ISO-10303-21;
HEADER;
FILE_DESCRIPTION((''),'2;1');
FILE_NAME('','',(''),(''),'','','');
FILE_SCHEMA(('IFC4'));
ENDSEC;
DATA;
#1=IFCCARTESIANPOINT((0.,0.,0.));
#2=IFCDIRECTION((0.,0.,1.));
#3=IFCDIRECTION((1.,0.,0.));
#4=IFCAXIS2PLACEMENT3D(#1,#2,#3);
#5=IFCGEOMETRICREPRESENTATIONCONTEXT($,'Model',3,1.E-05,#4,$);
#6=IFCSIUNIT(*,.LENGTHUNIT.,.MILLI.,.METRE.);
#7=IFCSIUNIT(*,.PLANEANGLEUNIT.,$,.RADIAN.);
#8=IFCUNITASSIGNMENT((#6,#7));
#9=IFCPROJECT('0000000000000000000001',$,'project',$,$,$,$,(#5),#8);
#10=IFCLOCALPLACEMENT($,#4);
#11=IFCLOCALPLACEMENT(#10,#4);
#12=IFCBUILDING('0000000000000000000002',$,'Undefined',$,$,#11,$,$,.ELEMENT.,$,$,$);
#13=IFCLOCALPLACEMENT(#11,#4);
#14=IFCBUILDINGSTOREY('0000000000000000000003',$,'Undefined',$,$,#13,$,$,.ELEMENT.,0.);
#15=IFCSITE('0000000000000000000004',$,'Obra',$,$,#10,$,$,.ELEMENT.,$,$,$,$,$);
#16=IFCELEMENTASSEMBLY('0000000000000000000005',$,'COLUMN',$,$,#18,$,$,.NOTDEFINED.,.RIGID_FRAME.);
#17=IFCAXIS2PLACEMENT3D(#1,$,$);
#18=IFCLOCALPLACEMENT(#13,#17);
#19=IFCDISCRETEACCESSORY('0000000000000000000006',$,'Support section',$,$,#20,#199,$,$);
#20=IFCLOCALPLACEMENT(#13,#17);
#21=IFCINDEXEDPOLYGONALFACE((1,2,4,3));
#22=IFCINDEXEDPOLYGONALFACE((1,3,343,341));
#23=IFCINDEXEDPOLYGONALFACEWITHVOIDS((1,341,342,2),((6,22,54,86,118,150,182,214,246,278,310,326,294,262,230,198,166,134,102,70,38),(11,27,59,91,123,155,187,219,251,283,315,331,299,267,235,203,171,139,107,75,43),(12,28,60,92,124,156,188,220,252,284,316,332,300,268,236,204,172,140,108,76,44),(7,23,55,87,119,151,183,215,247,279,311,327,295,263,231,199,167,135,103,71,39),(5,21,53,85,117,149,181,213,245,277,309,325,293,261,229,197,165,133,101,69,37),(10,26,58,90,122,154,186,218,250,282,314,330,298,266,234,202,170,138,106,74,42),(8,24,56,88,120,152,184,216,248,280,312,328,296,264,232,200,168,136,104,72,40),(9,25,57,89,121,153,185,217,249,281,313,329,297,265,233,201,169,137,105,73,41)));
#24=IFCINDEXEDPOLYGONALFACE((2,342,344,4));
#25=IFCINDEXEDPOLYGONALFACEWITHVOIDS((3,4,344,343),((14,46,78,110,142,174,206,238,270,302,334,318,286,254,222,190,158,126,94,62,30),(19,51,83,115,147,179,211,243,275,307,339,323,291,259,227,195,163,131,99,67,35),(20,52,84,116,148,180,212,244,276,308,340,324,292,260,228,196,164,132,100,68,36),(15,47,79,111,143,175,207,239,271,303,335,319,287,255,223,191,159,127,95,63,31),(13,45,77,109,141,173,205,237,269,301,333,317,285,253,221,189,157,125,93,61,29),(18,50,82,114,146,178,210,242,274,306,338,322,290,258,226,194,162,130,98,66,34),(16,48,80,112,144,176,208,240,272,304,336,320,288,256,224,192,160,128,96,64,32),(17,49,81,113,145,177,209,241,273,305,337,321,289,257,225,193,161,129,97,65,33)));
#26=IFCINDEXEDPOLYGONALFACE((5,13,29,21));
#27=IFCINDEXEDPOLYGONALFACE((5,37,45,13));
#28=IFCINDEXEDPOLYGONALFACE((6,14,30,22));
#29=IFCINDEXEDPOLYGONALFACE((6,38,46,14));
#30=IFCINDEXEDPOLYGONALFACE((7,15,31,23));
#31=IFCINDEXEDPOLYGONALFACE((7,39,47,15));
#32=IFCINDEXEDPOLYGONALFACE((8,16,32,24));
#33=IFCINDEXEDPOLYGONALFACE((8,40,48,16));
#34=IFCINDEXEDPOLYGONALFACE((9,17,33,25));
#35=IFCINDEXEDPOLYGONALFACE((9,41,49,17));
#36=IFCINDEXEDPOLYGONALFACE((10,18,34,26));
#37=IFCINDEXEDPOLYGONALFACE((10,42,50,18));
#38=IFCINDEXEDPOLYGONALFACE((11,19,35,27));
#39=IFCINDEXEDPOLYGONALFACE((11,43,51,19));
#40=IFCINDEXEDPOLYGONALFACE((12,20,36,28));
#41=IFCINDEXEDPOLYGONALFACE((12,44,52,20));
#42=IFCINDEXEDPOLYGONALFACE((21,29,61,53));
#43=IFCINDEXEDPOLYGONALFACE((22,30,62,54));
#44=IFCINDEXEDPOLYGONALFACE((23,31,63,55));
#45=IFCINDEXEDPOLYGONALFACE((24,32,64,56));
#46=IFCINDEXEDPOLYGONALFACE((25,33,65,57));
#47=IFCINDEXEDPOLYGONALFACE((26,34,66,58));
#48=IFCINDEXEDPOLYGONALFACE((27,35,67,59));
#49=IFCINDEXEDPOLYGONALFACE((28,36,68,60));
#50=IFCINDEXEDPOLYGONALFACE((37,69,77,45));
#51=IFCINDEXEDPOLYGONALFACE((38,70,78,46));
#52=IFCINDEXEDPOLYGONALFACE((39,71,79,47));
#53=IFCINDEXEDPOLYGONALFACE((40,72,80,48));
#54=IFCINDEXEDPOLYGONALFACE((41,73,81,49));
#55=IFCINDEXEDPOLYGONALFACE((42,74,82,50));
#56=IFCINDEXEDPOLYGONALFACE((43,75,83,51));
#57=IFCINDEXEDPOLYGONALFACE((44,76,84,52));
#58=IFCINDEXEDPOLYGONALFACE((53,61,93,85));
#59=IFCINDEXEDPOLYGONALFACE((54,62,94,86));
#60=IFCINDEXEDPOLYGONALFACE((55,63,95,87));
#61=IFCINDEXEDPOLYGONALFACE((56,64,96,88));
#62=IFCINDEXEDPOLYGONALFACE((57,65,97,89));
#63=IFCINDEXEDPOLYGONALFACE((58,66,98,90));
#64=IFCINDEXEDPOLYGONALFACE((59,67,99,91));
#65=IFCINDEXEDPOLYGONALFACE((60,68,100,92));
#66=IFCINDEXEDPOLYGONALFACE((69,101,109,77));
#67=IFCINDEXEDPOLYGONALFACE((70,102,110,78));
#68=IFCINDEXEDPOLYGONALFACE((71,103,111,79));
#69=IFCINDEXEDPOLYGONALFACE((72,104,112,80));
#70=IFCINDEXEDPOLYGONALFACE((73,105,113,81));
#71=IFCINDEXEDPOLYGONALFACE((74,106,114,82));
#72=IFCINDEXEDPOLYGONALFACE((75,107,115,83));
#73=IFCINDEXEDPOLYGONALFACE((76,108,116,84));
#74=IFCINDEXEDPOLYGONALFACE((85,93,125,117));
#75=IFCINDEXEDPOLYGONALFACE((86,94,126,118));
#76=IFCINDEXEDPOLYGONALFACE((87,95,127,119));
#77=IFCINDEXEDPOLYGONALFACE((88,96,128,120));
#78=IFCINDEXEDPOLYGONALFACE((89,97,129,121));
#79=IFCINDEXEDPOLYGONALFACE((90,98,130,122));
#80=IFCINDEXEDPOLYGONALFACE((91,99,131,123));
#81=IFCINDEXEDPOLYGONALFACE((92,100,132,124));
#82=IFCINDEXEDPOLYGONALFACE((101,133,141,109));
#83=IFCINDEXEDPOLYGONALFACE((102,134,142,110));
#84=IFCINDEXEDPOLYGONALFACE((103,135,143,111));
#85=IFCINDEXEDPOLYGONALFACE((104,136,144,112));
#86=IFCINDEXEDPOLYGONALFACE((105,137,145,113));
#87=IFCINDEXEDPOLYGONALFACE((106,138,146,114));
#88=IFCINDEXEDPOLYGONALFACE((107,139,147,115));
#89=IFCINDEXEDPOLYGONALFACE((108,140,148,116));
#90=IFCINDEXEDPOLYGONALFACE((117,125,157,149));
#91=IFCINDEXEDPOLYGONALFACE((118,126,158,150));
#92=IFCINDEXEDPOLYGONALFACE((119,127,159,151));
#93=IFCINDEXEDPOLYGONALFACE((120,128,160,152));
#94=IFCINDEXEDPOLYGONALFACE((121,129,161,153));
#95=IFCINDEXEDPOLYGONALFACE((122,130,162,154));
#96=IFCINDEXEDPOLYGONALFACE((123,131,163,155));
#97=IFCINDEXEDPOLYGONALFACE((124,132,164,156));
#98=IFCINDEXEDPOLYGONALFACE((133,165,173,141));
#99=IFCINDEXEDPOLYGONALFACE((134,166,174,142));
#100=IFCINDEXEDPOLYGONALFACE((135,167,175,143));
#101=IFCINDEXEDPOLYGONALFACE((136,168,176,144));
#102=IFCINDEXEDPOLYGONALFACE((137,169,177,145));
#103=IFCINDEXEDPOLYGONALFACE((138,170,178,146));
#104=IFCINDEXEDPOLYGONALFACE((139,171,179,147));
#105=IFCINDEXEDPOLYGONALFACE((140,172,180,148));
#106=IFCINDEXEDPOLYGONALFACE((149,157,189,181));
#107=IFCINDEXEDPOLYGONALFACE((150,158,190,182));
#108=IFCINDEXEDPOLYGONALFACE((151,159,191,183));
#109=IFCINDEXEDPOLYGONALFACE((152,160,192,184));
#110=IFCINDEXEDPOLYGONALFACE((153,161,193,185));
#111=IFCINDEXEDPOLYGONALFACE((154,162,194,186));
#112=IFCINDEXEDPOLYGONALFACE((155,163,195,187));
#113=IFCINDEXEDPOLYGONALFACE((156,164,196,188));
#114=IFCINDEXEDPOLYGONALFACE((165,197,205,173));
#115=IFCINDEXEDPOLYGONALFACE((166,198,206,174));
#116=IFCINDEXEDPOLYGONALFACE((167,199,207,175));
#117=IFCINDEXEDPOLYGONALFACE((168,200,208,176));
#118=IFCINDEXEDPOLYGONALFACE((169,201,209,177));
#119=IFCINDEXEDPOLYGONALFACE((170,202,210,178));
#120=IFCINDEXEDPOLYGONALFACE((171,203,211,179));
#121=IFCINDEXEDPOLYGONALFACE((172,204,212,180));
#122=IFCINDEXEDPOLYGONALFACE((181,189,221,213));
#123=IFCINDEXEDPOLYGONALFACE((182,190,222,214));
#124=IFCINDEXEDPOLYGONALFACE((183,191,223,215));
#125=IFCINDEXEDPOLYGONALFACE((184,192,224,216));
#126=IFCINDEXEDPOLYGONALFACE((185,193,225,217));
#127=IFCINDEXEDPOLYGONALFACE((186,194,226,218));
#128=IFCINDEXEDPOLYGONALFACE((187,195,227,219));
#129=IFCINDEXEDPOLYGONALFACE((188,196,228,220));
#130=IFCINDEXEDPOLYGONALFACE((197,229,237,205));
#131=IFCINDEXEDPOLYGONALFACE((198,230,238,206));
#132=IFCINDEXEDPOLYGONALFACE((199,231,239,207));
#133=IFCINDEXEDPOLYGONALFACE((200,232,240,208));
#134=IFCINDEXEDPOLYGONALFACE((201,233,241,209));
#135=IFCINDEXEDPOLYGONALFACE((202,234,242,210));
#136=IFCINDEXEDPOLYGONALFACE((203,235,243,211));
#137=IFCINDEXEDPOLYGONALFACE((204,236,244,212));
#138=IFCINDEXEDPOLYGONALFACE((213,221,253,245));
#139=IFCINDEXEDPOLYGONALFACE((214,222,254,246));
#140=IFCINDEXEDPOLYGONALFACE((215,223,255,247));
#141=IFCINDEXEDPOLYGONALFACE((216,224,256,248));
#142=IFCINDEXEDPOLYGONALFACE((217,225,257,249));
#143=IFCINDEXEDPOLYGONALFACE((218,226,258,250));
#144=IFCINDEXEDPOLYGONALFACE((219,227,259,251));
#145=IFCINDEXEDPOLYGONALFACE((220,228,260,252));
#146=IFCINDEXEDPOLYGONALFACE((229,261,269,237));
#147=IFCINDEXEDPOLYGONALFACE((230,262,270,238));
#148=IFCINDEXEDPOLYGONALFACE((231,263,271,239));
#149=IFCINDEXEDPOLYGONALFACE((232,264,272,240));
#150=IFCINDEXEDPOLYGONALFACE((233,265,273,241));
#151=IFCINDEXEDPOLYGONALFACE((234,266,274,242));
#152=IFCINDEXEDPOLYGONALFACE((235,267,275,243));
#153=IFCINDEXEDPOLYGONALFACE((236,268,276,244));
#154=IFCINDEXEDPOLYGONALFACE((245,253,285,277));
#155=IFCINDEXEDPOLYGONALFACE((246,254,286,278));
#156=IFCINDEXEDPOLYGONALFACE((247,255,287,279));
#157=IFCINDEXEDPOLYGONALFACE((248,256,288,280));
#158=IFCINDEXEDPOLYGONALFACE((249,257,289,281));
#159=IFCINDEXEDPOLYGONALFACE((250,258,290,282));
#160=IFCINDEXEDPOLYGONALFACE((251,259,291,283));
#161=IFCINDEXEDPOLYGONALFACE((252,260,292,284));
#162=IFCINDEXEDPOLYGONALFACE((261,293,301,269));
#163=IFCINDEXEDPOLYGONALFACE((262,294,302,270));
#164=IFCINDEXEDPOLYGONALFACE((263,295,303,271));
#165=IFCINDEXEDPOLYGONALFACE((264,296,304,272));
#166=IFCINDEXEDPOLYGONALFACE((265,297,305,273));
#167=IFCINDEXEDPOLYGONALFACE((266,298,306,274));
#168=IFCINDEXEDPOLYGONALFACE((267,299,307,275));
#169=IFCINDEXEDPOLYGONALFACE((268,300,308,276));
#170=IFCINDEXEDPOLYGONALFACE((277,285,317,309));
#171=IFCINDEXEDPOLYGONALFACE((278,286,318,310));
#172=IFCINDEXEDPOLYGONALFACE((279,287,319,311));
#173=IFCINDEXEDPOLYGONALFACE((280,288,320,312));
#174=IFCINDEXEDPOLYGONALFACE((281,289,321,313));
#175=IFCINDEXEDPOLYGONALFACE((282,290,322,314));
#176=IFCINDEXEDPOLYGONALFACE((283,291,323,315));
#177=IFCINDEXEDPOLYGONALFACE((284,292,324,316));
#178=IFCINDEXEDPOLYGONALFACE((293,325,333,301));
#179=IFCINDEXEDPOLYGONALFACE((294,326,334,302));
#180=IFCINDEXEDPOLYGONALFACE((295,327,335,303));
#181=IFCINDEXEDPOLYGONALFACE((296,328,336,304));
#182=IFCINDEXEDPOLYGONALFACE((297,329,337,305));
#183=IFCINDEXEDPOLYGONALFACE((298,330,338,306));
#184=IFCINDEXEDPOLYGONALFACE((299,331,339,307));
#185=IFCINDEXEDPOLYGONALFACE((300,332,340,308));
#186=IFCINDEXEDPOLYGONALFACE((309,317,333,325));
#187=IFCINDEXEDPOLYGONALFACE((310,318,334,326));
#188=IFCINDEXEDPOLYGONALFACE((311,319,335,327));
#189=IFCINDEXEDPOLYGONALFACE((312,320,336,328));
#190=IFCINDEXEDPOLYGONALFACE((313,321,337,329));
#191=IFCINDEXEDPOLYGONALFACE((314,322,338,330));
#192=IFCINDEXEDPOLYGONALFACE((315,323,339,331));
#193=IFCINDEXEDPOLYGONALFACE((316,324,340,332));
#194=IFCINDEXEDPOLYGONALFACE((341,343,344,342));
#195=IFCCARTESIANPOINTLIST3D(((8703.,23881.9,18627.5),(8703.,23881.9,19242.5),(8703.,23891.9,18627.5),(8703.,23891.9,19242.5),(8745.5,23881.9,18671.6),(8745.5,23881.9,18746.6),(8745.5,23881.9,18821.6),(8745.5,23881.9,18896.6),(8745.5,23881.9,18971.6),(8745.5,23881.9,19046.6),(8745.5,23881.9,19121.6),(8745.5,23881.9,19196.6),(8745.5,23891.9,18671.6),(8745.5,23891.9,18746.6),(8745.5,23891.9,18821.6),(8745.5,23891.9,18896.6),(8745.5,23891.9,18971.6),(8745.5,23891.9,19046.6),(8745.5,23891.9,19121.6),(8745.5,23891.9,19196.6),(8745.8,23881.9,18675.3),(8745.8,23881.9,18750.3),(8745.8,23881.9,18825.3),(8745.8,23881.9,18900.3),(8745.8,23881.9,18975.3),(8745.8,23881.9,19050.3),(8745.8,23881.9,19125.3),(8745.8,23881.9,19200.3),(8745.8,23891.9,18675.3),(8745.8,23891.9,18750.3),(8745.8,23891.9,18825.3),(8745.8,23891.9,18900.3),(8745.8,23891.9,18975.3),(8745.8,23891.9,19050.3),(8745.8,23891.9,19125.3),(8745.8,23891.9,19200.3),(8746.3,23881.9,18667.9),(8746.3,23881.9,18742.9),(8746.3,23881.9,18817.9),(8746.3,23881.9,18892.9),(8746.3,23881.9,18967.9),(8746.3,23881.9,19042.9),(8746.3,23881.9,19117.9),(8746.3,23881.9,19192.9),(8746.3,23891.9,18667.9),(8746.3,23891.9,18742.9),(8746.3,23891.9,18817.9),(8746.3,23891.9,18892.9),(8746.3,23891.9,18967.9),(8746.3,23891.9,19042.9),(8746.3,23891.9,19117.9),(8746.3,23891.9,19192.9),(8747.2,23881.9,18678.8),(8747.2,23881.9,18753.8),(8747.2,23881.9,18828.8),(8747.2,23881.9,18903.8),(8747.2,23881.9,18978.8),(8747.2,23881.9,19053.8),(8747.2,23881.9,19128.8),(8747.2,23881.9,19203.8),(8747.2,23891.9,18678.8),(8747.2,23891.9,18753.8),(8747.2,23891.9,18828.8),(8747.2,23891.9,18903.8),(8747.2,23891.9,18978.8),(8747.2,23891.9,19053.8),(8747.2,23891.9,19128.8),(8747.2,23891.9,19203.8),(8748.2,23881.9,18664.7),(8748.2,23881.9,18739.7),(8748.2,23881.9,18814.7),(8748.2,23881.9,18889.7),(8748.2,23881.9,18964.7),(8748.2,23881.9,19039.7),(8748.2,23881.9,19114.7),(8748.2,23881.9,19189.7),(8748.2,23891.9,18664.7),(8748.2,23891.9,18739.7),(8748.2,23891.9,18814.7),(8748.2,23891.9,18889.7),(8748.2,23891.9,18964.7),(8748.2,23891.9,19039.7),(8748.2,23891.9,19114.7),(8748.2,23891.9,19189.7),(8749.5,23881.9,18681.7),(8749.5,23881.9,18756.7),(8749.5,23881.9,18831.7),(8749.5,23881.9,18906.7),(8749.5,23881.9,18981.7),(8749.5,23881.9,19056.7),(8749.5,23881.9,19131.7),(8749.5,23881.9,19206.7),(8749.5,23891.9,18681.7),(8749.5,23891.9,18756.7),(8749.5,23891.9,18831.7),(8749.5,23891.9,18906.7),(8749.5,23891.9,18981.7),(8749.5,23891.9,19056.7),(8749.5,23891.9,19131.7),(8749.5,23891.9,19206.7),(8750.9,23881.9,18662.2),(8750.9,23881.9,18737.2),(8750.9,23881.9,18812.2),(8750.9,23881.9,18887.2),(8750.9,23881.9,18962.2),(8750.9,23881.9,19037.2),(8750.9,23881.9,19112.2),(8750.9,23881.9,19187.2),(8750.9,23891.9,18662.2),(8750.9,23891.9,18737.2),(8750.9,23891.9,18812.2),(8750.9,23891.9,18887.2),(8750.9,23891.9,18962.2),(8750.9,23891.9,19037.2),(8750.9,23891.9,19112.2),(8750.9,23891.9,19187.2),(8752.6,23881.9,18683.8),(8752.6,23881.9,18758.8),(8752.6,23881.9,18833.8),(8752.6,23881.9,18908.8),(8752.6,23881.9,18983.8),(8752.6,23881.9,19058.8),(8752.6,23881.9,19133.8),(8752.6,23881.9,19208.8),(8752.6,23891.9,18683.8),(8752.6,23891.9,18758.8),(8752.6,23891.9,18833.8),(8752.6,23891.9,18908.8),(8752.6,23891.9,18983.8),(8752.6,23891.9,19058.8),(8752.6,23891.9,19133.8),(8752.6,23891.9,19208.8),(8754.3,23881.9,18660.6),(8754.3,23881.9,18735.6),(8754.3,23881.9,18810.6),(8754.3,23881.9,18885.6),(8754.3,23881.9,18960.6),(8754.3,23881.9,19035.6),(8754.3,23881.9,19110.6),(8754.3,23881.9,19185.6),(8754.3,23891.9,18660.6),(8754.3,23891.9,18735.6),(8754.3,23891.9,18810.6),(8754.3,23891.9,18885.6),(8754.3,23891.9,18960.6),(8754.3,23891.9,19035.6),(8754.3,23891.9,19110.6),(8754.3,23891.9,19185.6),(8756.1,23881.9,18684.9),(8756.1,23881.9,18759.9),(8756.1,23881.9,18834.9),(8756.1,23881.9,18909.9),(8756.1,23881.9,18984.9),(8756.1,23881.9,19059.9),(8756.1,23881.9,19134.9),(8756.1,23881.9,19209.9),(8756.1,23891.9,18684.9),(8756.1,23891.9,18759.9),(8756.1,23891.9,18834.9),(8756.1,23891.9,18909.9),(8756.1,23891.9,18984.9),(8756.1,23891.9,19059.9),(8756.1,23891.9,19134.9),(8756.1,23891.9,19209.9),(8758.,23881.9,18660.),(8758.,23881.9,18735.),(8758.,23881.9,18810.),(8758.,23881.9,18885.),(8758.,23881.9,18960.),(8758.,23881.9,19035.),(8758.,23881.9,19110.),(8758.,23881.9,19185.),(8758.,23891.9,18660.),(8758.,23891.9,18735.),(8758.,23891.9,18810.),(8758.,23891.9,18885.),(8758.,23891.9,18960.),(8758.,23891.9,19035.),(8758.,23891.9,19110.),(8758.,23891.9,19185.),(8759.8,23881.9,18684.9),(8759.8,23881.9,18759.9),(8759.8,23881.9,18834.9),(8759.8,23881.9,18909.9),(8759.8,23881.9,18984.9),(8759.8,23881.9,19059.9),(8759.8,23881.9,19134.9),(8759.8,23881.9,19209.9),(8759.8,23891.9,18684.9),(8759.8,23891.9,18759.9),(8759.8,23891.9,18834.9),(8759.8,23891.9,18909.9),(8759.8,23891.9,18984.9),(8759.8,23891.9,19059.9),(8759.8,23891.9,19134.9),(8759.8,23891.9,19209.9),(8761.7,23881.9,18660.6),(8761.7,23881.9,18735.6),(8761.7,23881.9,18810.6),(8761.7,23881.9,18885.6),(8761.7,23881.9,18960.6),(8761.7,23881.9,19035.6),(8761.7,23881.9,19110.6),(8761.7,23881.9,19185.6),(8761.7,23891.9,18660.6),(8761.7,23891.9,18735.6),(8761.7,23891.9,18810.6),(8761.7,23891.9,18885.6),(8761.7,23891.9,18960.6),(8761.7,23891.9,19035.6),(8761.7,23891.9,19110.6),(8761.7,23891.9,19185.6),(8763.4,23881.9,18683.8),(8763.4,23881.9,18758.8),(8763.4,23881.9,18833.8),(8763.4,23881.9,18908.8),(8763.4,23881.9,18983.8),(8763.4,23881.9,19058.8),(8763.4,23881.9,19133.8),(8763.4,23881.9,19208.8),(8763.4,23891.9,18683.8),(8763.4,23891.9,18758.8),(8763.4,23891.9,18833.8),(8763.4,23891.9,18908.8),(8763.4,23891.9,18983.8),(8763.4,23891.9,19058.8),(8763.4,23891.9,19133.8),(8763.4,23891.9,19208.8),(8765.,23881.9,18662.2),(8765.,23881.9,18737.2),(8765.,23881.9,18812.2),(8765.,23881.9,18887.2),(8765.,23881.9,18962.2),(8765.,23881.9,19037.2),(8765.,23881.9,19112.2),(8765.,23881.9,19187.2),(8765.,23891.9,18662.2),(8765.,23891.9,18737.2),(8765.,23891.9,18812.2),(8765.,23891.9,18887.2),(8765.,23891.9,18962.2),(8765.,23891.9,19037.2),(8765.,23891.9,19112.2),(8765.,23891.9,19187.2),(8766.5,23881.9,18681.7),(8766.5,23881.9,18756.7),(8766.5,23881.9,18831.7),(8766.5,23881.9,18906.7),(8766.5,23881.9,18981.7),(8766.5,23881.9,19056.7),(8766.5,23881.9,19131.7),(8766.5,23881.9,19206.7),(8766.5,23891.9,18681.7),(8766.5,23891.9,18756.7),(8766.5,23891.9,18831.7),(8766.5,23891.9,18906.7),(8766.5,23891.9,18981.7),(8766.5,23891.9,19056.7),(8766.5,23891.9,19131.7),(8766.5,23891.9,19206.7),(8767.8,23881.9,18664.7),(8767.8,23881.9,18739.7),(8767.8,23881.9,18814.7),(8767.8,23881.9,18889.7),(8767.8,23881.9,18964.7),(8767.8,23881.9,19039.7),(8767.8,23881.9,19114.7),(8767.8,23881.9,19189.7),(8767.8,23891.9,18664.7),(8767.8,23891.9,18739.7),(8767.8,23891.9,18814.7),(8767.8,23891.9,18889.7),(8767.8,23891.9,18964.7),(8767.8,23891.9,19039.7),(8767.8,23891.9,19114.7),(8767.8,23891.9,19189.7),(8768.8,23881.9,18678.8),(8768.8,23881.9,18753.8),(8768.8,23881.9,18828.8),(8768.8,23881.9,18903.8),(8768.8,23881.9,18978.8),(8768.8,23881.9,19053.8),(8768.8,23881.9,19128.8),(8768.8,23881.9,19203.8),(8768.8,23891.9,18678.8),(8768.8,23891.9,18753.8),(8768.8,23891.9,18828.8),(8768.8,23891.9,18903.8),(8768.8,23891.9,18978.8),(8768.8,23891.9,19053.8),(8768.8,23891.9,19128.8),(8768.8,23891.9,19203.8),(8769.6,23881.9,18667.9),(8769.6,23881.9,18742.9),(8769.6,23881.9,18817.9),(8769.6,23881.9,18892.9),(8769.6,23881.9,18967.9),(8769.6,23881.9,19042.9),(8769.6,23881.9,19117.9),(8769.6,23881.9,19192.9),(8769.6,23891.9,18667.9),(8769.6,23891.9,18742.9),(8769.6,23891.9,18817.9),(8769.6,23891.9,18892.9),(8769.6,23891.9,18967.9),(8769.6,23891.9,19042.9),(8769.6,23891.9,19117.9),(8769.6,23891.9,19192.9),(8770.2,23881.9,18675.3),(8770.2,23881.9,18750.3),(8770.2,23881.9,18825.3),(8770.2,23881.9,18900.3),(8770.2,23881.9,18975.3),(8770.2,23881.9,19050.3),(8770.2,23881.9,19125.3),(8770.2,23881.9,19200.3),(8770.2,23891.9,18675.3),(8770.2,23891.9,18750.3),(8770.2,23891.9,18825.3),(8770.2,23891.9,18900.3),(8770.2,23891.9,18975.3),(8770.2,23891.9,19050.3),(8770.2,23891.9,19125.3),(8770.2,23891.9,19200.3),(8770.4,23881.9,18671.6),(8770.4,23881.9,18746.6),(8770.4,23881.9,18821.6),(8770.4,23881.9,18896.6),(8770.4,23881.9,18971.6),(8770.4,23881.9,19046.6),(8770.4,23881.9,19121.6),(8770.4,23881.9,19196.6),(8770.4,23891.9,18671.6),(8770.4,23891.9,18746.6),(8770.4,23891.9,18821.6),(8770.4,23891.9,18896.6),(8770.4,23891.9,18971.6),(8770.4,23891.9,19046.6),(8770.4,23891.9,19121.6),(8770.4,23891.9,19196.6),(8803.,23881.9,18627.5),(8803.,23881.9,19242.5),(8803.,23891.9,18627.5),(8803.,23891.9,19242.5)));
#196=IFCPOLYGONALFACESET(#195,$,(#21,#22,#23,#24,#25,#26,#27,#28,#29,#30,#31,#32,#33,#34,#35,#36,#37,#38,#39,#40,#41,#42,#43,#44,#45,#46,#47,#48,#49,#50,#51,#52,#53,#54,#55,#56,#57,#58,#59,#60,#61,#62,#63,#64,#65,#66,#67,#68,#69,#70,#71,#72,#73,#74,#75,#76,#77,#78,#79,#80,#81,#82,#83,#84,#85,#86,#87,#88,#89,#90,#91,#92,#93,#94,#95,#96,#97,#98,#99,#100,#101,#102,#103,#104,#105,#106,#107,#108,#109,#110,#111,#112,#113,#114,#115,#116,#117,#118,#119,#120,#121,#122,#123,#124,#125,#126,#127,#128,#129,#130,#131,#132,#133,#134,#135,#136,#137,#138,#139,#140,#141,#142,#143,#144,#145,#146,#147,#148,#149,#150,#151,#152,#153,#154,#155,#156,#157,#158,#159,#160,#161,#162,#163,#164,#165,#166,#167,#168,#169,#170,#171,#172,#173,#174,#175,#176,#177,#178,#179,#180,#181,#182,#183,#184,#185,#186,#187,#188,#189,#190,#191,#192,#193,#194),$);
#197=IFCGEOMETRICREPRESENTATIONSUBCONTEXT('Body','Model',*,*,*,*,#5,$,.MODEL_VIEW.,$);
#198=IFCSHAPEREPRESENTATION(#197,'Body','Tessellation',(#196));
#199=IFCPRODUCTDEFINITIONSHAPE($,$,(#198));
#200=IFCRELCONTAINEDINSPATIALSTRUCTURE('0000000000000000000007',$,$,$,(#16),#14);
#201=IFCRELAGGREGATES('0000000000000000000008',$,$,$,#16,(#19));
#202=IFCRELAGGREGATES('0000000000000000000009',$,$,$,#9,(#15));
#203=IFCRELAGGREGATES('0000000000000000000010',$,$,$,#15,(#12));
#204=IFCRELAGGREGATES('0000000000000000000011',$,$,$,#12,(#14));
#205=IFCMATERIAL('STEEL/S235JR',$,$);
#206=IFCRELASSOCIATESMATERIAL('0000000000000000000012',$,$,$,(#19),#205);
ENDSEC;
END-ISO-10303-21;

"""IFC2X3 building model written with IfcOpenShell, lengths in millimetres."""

from ifc_helpers import new_model, si_unit, frame, origin_with_axes, origin_2d_with_axis, place, context, subcontext, project, spatial, rectangle, circle, extrude, source, transform, mapped, material, element, aggregate, save


model = new_model("IFC2X3")

# Units and contexts
model_context = context("Model", 3, precision=1e-05, world=origin_with_axes())
body_context = subcontext(model_context, "Body", "Model", "MODEL_VIEW")
ifc_project = project(units=[si_unit("LENGTHUNIT", "METRE", prefix="MILLI"), si_unit("PLANEANGLEUNIT", "RADIAN")], contexts=[model_context])

# Site, building, storey
site_placement = place(None, origin_with_axes())
site = spatial("IfcSite", under=ifc_project, at=site_placement, Name="Obra", CompositionType="ELEMENT")
building_placement = place(site_placement, origin_with_axes())
building = spatial("IfcBuilding", under=site, at=building_placement, Name="Undefined", CompositionType="ELEMENT")
storey_placement = place(building_placement, origin_with_axes())
storey = spatial("IfcBuildingStorey", under=building, at=storey_placement, Name="Undefined", CompositionType="ELEMENT", Elevation=0.0)

# Element assembly
assembly_1_placement = place(storey_placement, origin_with_axes())
assembly_1 = element("IfcElementAssembly", 1, at=assembly_1_placement, inside=storey, Name="COLUMN", AssemblyPlace="NOTDEFINED", PredefinedType="RIGID_FRAME")
ifc_material_1 = material(Name="STEEL/S235JR")

# Discrete accessory, opening
discrete_accessory_1_placement = place(assembly_1_placement, frame((8753.0, 23886.9, 18627.5), z_axis=(0.0, 0.0, 1.0), x_axis=(-1.0, 0.0, 0.0)))
discrete_accessory_1 = element("IfcDiscreteAccessory", 2, at=discrete_accessory_1_placement, material=ifc_material_1, Name="Support section", context=body_context, shape_type="SweptSolid", body=[
    extrude(rectangle(XDim=10.0, YDim=100.0, at=origin_2d_with_axis()), frame((0.0, 0.0, 615.0), z_axis=(0.0, 0.0, -1.0), x_axis=(0.0, 1.0, 0.0)), (0.0, 0.0, 1.0), 615.0),
])
shared_shape_1 = source(origin_with_axes(), body_context, "Body", "SweptSolid", [
    extrude(circle(Radius=12.5, at=origin_2d_with_axis()), frame((0.0, -15.1, 0.0), z_axis=(0.0, 1.0, 0.0), x_axis=(1.0, 0.0, 0.0)), (0.0, 0.0, 1.0), 10.2),
])
opening_1_placement = place(assembly_1_placement, frame((8713.0, 23896.9, 19350.0), z_axis=(1.0, 0.0, 0.0), x_axis=(0.0, 0.0, -1.0)))
element("IfcOpeningElement", 3, at=opening_1_placement, cuts=discrete_accessory_1, ObjectType="Opening", context=body_context, shape_type="MappedRepresentation", body=[
    mapped(shared_shape_1, transform((152.5, 0.0, 45.0))),
    mapped(shared_shape_1, transform((227.5, 0.0, 45.0))),
    mapped(shared_shape_1, transform((302.5, 0.0, 45.0))),
    mapped(shared_shape_1, transform((377.5, 0.0, 45.0))),
    mapped(shared_shape_1, transform((452.5, 0.0, 45.0))),
    mapped(shared_shape_1, transform((527.5, 0.0, 45.0))),
    mapped(shared_shape_1, transform((602.5, 0.0, 45.0))),
    mapped(shared_shape_1, transform((677.5, 0.0, 45.0))),
])
aggregate(assembly_1, [discrete_accessory_1])

save(model, "model.ifc")
